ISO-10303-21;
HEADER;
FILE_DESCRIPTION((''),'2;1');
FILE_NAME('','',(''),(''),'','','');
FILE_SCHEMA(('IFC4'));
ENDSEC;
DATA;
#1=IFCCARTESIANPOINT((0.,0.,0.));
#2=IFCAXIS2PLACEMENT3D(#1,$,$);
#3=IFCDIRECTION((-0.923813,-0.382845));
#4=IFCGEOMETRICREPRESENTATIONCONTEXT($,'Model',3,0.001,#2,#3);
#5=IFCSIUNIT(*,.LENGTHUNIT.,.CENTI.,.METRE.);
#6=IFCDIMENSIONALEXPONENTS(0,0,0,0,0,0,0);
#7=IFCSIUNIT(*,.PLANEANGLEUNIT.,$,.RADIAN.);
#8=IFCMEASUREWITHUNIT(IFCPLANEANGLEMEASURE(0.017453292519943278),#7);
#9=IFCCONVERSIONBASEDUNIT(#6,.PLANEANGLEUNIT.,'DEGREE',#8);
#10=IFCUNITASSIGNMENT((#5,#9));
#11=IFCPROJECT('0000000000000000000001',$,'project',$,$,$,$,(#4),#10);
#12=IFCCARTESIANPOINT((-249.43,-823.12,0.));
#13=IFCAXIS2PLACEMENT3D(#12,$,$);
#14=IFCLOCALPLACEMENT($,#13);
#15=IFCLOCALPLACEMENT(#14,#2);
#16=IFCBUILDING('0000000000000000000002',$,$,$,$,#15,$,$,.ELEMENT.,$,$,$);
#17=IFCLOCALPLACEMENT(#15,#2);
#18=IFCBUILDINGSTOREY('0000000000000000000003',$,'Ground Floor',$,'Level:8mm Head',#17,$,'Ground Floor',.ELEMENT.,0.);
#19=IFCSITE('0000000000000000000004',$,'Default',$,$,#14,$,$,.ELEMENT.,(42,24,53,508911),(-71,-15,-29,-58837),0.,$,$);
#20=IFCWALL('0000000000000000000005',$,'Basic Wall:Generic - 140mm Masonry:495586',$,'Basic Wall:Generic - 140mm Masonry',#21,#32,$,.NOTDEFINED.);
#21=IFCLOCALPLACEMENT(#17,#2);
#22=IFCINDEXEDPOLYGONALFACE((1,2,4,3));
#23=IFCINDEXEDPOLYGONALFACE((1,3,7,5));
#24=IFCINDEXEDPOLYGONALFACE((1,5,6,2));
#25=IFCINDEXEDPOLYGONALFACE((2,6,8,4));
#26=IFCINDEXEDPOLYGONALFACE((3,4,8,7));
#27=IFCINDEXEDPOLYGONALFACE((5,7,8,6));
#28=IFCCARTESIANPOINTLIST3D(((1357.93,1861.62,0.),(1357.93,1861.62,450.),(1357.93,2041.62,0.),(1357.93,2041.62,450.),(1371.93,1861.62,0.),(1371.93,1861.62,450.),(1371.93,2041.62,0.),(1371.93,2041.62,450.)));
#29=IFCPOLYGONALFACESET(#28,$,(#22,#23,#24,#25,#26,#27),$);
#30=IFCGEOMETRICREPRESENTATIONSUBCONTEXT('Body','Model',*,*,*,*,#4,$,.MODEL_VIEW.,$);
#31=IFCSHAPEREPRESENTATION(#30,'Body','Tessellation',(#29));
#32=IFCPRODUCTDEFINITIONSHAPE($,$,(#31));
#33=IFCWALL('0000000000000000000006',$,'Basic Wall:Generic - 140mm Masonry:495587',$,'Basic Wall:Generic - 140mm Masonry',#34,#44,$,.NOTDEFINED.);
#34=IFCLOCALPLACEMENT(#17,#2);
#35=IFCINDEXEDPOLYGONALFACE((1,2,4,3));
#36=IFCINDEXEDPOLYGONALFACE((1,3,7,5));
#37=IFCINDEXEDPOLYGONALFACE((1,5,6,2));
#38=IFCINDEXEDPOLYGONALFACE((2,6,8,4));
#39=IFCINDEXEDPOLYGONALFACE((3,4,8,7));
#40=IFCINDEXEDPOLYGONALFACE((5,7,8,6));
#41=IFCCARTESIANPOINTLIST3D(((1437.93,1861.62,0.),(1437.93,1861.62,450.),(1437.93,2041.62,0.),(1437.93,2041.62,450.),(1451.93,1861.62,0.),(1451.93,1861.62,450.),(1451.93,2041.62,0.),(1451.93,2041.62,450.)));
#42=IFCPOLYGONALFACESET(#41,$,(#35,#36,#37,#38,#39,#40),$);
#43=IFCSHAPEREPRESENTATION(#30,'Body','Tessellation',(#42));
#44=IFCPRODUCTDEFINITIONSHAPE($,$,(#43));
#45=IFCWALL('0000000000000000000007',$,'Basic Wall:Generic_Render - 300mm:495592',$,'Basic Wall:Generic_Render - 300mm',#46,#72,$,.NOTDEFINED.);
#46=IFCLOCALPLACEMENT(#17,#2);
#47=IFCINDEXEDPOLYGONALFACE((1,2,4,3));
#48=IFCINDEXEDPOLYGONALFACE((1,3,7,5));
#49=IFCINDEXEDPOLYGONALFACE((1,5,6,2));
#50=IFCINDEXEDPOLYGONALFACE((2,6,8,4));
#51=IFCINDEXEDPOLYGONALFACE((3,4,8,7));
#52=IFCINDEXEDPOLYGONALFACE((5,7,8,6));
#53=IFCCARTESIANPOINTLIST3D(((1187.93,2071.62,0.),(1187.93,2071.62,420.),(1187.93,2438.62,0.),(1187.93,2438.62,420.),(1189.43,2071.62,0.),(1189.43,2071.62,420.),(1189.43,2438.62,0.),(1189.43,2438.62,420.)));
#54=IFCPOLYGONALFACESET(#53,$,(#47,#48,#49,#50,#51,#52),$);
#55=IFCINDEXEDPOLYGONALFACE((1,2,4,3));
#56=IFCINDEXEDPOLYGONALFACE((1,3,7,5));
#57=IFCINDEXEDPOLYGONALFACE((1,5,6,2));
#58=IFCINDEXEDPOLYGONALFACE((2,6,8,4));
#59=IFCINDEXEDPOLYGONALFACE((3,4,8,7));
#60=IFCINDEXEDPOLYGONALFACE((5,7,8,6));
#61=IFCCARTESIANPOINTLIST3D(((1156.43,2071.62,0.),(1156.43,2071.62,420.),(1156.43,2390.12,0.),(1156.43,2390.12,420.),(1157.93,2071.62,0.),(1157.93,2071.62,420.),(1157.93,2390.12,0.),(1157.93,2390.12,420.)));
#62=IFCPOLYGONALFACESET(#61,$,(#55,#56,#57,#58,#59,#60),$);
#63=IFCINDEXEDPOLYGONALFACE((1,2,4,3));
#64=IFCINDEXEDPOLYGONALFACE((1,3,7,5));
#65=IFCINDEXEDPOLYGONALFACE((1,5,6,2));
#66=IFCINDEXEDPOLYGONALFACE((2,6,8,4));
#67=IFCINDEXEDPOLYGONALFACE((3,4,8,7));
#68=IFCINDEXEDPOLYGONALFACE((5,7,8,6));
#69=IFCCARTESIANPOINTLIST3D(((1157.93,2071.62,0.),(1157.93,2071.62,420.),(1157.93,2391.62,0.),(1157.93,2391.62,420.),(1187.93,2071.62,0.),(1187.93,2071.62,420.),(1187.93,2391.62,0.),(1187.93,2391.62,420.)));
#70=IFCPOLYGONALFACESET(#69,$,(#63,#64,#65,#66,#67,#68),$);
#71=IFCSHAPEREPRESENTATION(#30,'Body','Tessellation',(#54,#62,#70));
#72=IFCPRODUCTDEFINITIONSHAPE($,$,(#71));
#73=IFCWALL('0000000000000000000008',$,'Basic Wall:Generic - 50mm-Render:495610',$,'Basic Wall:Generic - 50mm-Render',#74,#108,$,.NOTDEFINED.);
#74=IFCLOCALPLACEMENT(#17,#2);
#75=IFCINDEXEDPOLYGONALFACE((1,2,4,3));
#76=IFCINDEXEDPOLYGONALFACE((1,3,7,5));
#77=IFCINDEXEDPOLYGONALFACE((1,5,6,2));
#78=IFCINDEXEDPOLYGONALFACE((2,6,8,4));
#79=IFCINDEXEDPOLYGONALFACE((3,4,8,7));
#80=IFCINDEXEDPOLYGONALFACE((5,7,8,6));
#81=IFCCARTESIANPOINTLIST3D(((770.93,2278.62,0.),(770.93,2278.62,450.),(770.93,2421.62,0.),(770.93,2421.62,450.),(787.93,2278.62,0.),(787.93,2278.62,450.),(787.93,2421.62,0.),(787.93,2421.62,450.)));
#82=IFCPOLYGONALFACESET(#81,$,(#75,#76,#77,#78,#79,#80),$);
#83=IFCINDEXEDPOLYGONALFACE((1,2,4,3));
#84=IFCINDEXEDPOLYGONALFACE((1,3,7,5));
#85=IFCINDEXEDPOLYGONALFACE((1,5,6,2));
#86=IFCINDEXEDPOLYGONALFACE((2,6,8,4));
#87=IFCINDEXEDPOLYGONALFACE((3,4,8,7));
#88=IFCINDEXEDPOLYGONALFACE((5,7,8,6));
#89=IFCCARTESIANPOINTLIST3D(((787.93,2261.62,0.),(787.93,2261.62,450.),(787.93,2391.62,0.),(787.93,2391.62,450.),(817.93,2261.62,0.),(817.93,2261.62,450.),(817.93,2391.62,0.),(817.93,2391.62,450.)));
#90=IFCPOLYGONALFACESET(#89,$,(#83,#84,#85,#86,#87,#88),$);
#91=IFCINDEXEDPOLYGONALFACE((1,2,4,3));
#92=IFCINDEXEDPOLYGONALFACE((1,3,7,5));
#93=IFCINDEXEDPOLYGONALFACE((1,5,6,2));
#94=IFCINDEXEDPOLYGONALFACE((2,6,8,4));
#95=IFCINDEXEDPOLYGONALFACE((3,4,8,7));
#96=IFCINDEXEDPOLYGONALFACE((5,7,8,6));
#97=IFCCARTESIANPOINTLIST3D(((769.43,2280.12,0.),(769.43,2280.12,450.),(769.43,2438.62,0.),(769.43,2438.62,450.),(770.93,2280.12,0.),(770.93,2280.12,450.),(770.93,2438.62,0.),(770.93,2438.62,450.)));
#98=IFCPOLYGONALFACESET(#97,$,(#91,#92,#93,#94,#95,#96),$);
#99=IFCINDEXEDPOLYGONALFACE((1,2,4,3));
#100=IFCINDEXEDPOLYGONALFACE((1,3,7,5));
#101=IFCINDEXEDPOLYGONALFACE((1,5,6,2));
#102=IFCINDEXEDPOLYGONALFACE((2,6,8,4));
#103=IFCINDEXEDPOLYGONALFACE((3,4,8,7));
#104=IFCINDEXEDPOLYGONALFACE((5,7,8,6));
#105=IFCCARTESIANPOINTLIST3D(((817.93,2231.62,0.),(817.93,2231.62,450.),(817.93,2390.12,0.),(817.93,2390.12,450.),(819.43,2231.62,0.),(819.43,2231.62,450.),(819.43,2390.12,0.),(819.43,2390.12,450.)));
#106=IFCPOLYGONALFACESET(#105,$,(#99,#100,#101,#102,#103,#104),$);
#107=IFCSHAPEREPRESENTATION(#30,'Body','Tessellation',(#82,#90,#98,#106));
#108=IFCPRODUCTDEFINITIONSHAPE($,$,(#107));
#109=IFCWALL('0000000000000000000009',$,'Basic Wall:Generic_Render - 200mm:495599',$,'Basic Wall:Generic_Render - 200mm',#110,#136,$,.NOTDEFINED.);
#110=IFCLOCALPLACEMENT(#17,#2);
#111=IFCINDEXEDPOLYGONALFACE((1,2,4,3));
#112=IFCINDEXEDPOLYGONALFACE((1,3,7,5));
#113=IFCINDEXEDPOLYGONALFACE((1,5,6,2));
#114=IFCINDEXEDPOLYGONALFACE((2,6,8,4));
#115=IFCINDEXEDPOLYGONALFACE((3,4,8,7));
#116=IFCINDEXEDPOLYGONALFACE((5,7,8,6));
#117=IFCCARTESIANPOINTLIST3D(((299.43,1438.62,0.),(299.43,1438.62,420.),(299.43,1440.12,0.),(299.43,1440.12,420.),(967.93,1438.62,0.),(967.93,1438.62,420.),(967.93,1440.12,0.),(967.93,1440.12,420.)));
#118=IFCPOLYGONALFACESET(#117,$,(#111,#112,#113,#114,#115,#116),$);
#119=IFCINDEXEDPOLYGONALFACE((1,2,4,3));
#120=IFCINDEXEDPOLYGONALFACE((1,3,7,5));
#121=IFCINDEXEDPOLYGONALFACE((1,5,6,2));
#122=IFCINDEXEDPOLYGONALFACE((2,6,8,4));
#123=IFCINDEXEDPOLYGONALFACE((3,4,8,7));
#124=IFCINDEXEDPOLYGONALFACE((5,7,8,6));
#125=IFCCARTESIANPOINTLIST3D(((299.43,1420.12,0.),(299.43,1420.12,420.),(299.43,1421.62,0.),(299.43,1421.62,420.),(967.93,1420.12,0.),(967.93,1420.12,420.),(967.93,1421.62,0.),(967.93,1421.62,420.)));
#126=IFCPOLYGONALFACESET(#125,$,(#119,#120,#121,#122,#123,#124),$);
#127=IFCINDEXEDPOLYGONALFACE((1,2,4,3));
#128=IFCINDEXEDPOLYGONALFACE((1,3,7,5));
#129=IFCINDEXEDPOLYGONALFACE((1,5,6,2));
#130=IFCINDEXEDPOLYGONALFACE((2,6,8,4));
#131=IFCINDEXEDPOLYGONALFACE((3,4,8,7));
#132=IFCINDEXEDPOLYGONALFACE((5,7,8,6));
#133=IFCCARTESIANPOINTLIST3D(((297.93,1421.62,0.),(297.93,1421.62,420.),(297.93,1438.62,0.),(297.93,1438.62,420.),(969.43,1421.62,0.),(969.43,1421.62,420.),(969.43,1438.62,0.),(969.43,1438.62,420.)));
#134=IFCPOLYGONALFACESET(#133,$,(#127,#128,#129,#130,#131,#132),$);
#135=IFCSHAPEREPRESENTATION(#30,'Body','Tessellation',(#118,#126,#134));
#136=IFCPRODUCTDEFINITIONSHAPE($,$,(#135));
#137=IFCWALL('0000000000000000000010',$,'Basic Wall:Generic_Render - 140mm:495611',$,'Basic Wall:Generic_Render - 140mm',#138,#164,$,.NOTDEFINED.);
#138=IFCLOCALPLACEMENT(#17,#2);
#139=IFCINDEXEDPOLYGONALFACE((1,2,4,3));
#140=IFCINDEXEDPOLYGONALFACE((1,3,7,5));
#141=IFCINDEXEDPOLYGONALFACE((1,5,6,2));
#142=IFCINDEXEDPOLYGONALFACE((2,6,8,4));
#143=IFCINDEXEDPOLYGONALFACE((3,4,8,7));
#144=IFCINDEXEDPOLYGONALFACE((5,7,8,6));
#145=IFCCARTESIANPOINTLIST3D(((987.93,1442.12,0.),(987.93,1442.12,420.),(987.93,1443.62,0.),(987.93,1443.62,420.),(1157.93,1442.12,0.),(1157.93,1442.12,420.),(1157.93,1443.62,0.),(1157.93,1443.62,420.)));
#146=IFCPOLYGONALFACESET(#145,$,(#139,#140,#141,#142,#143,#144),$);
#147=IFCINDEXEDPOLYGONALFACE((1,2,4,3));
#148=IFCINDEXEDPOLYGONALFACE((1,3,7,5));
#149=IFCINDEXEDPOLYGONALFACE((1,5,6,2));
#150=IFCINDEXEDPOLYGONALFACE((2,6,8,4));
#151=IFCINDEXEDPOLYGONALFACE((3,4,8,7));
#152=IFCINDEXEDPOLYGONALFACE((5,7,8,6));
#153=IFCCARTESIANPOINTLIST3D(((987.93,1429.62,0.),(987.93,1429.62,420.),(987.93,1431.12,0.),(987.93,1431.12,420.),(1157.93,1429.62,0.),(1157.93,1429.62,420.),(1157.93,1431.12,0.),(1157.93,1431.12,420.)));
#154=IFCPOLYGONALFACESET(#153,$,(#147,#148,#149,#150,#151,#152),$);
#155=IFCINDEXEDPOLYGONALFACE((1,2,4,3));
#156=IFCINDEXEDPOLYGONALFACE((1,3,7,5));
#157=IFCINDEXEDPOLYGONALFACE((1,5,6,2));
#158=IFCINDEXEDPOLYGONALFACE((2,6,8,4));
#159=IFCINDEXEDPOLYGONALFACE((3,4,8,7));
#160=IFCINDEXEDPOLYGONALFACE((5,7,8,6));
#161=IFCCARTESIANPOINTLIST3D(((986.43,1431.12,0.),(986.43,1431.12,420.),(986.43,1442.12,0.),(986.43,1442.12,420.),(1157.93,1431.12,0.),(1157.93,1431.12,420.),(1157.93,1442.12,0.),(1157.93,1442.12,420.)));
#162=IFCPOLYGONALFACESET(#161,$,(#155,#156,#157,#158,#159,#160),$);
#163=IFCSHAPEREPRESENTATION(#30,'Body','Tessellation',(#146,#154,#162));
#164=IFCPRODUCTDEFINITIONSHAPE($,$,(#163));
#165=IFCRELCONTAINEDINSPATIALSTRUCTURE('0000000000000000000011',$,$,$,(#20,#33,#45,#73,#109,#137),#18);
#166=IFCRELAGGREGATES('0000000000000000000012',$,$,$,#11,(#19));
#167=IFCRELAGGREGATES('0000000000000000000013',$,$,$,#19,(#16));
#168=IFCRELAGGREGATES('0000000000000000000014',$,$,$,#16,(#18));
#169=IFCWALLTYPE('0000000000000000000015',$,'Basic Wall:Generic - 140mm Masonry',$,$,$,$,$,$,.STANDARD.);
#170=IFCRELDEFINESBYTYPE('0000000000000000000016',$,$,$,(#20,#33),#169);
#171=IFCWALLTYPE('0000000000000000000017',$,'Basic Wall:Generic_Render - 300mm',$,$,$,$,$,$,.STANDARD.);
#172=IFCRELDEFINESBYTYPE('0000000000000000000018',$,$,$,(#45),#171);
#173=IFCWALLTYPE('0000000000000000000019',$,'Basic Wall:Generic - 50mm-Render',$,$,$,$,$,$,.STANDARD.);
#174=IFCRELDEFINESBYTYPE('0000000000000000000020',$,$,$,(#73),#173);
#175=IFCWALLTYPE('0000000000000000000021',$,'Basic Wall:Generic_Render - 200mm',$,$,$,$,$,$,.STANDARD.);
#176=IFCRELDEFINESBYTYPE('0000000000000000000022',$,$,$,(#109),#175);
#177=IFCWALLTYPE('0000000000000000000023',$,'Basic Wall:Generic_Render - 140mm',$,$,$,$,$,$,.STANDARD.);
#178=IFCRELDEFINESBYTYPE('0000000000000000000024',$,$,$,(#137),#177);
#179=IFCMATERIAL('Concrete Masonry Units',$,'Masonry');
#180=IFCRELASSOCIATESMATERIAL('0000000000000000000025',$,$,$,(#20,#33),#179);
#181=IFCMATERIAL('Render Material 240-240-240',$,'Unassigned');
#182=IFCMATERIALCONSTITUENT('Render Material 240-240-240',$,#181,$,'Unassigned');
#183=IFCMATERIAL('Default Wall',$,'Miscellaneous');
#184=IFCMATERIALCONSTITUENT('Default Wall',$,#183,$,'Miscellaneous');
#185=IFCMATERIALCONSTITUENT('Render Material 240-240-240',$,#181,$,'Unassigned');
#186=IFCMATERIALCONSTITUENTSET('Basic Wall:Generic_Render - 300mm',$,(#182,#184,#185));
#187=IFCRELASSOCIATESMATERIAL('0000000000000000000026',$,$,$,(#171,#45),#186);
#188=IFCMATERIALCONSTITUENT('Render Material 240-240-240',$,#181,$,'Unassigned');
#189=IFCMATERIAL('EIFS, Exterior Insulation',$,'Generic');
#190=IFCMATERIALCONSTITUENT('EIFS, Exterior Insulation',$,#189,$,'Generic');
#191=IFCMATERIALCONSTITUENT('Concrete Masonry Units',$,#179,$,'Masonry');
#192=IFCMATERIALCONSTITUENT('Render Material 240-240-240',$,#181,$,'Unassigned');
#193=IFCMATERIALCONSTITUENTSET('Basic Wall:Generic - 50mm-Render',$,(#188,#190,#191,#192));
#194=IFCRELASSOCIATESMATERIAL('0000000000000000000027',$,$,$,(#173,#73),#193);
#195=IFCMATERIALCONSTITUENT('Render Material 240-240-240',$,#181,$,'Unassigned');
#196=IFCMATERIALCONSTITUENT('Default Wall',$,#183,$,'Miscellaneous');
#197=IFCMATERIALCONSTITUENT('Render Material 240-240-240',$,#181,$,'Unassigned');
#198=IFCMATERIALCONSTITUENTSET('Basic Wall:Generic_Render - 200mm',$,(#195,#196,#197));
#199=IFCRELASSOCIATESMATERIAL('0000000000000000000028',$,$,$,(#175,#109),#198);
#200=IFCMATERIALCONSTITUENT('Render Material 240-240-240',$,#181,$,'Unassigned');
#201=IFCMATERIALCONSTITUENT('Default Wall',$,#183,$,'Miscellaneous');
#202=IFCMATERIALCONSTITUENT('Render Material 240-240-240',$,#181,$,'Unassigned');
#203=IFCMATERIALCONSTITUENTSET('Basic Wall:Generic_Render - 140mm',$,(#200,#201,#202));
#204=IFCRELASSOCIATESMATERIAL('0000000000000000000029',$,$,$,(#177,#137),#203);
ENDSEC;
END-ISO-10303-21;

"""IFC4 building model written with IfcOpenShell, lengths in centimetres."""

from ifc_helpers import new_model, entity, si_unit, converted_unit, direction, frame, origin, place, context, subcontext, project, spatial, indexed_curve, outline, extrude, material, constituent, constituent_set, type_object, element, save


model = new_model("IFC4")

# Units and contexts
model_context = context("Model", 3, precision=0.001, world=origin(), true_north=direction((-0.923813, -0.382845)))
body_context = subcontext(model_context, "Body", "Model", "MODEL_VIEW")
ifc_project = project(units=[si_unit("LENGTHUNIT", "METRE", prefix="CENTI"), converted_unit("PLANEANGLEUNIT", "DEGREE", entity("IfcPlaneAngleMeasure", 0.017453292519943278), si_unit("PLANEANGLEUNIT", "RADIAN"), dimensions=[0, 0, 0, 0, 0, 0, 0])], contexts=[model_context])

# Site, building, storey
site_placement = place(None, frame((-249.43, -823.12, 0.0)))
site = spatial("IfcSite", under=ifc_project, at=site_placement, Name="Default", CompositionType="ELEMENT", RefLatitude=(42, 24, 53, 508911), RefLongitude=(-71, -15, -29, -58837), RefElevation=0.0)
building_placement = place(site_placement, origin())
building = spatial("IfcBuilding", under=site, at=building_placement, CompositionType="ELEMENT")
storey_placement = place(building_placement, origin())
storey = spatial("IfcBuildingStorey", under=building, at=storey_placement, Name="Ground Floor", ObjectType="Level:8mm Head", LongName="Ground Floor", CompositionType="ELEMENT", Elevation=0.0)

# Walls
ifc_material_1 = material(Name="Concrete Masonry Units", Category="Masonry")
wall_type_1 = type_object("IfcWallType", Name="Basic Wall:Generic - 140mm Masonry", PredefinedType="STANDARD")
wall_1_placement = place(storey_placement, frame((1364.93, 2041.62, 0.0), z_axis=(0.0, 0.0, 1.0), x_axis=(0.0, -1.0, 0.0)))
element("IfcWall", 1, at=wall_1_placement, inside=storey, type_object=wall_type_1, material=ifc_material_1, Name="Basic Wall:Generic - 140mm Masonry:495586", ObjectType="Basic Wall:Generic - 140mm Masonry", PredefinedType="NOTDEFINED", context=body_context, shape_type="SweptSolid", body=[
    extrude(outline(indexed_curve([(180.0, 7.0), (0.0, 7.0), (0.0, -7.0), (180.0, -7.0), (180.0, 7.0)], self_intersect=False)), origin(), (0.0, 0.0, 1.0), 450.0),
])
wall_2_placement = place(storey_placement, frame((1444.93, 2041.62, 0.0), z_axis=(0.0, 0.0, 1.0), x_axis=(0.0, -1.0, 0.0)))
element("IfcWall", 2, at=wall_2_placement, inside=storey, type_object=wall_type_1, material=ifc_material_1, Name="Basic Wall:Generic - 140mm Masonry:495587", ObjectType="Basic Wall:Generic - 140mm Masonry", PredefinedType="NOTDEFINED", context=body_context, shape_type="SweptSolid", body=[
    extrude(outline(indexed_curve([(180.0, 7.0), (0.0, 7.0), (0.0, -7.0), (180.0, -7.0), (180.0, 7.0)], self_intersect=False)), origin(), (0.0, 0.0, 1.0), 450.0),
])
ifc_material_2 = material(Name="Render Material 240-240-240", Category="Unassigned")
ifc_constituent_1 = constituent(ifc_material_2, Name="Render Material 240-240-240", Category="Unassigned")
ifc_material_3 = material(Name="Default Wall", Category="Miscellaneous")
ifc_constituent_2 = constituent(ifc_material_3, Name="Default Wall", Category="Miscellaneous")
ifc_constituent_3 = constituent(ifc_material_2, Name="Render Material 240-240-240", Category="Unassigned")
ifc_constituent_set_1 = constituent_set(constituents=[ifc_constituent_1, ifc_constituent_2, ifc_constituent_3], Name="Basic Wall:Generic_Render - 300mm")
wall_type_2 = type_object("IfcWallType", Name="Basic Wall:Generic_Render - 300mm", PredefinedType="STANDARD", material=ifc_constituent_set_1)
wall_3_placement = place(storey_placement, frame((1172.93, 2071.62, 0.0), z_axis=(0.0, 0.0, 1.0), x_axis=(0.0, 1.0, 0.0)))
element("IfcWall", 3, at=wall_3_placement, inside=storey, type_object=wall_type_2, material=ifc_constituent_set_1, Name="Basic Wall:Generic_Render - 300mm:495592", ObjectType="Basic Wall:Generic_Render - 300mm", PredefinedType="NOTDEFINED", context=body_context, shape_type="SweptSolid", body=[
    extrude(outline(indexed_curve([(-0.75, -183.5), (0.75, -183.5), (0.75, 183.5), (-0.75, 183.5), (-0.75, -183.5)], self_intersect=False)), frame((183.5, -15.75, 0.0), z_axis=(0.0, 0.0, 1.0), x_axis=(0.0, 1.0, 0.0)), (0.0, 0.0, 1.0), 420.0),
    extrude(outline(indexed_curve([(-0.75, -159.25), (0.75, -159.25), (0.75, 159.25), (-0.75, 159.25), (-0.75, -159.25)], self_intersect=False)), frame((159.25, 15.75, 0.0), z_axis=(0.0, 0.0, 1.0), x_axis=(0.0, -1.0, 0.0)), (0.0, 0.0, 1.0), 420.0),
    extrude(outline(indexed_curve([(-160.0, -15.0), (160.0, -15.0), (160.0, 15.0), (-160.0, 15.0), (-160.0, -15.0)], self_intersect=False)), frame((160.0, 0.0, 0.0)), (0.0, 0.0, 1.0), 420.0),
])
ifc_constituent_4 = constituent(ifc_material_2, Name="Render Material 240-240-240", Category="Unassigned")
ifc_material_4 = material(Name="EIFS, Exterior Insulation", Category="Generic")
ifc_constituent_5 = constituent(ifc_material_4, Name="EIFS, Exterior Insulation", Category="Generic")
ifc_constituent_6 = constituent(ifc_material_1, Name="Concrete Masonry Units", Category="Masonry")
ifc_constituent_7 = constituent(ifc_material_2, Name="Render Material 240-240-240", Category="Unassigned")
ifc_constituent_set_2 = constituent_set(constituents=[ifc_constituent_4, ifc_constituent_5, ifc_constituent_6, ifc_constituent_7], Name="Basic Wall:Generic - 50mm-Render")
wall_type_3 = type_object("IfcWallType", Name="Basic Wall:Generic - 50mm-Render", PredefinedType="STANDARD", material=ifc_constituent_set_2)
wall_4_placement = place(storey_placement, frame((794.43, 2280.12, 0.0), z_axis=(0.0, 0.0, 1.0), x_axis=(0.0, 1.0, 0.0)))
element("IfcWall", 4, at=wall_4_placement, inside=storey, type_object=wall_type_3, material=ifc_constituent_set_2, Name="Basic Wall:Generic - 50mm-Render:495610", ObjectType="Basic Wall:Generic - 50mm-Render", PredefinedType="NOTDEFINED", context=body_context, shape_type="SweptSolid", body=[
    extrude(outline(indexed_curve([(-71.5, -8.5), (71.5, -8.5), (71.5, 8.5), (-71.5, 8.5), (-71.5, -8.5)], self_intersect=False)), frame((70.0, 15.0, 0.0)), (0.0, 0.0, 1.0), 450.0),
    extrude(outline(indexed_curve([(-65.0, -15.0), (65.0, -15.0), (65.0, 15.0), (-65.0, 15.0), (-65.0, -15.0)], self_intersect=False)), frame((46.5, -8.5, 0.0)), (0.0, 0.0, 1.0), 450.0),
    extrude(outline(indexed_curve([(-0.75, -79.25), (0.75, -79.25), (0.75, 79.25), (-0.75, 79.25), (-0.75, -79.25)], self_intersect=False)), frame((79.25, 24.25, 0.0), z_axis=(0.0, 0.0, 1.0), x_axis=(0.0, -1.0, 0.0)), (0.0, 0.0, 1.0), 450.0),
    extrude(outline(indexed_curve([(-0.75, -79.25), (0.75, -79.25), (0.75, 79.25), (-0.75, 79.25), (-0.75, -79.25)], self_intersect=False)), frame((30.75, -24.25, 0.0), z_axis=(0.0, 0.0, 1.0), x_axis=(0.0, 1.0, 0.0)), (0.0, 0.0, 1.0), 450.0),
])
ifc_constituent_8 = constituent(ifc_material_2, Name="Render Material 240-240-240", Category="Unassigned")
ifc_constituent_9 = constituent(ifc_material_3, Name="Default Wall", Category="Miscellaneous")
ifc_constituent_10 = constituent(ifc_material_2, Name="Render Material 240-240-240", Category="Unassigned")
ifc_constituent_set_3 = constituent_set(constituents=[ifc_constituent_8, ifc_constituent_9, ifc_constituent_10], Name="Basic Wall:Generic_Render - 200mm")
wall_type_4 = type_object("IfcWallType", Name="Basic Wall:Generic_Render - 200mm", PredefinedType="STANDARD", material=ifc_constituent_set_3)
wall_5_placement = place(storey_placement, frame((967.93, 1430.12, 0.0), z_axis=(0.0, 0.0, 1.0), x_axis=(-1.0, 0.0, 0.0)))
element("IfcWall", 5, at=wall_5_placement, inside=storey, type_object=wall_type_4, material=ifc_constituent_set_3, Name="Basic Wall:Generic_Render - 200mm:495599", ObjectType="Basic Wall:Generic_Render - 200mm", PredefinedType="NOTDEFINED", context=body_context, shape_type="SweptSolid", body=[
    extrude(outline(indexed_curve([(-0.75, -334.25), (0.75, -334.25), (0.75, 334.25), (-0.75, 334.25), (-0.75, -334.25)], self_intersect=False)), frame((334.25, -9.25, 0.0), z_axis=(0.0, 0.0, 1.0), x_axis=(0.0, 1.0, 0.0)), (0.0, 0.0, 1.0), 420.0),
    extrude(outline(indexed_curve([(-0.75, -334.25), (0.75, -334.25), (0.75, 334.25), (-0.75, 334.25), (-0.75, -334.25)], self_intersect=False)), frame((334.25, 9.25, 0.0), z_axis=(0.0, 0.0, 1.0), x_axis=(0.0, -1.0, 0.0)), (0.0, 0.0, 1.0), 420.0),
    extrude(outline(indexed_curve([(-335.75, -8.5), (335.75, -8.5), (335.75, 8.5), (-335.75, 8.5), (-335.75, -8.5)], self_intersect=False)), frame((334.25, 0.0, 0.0)), (0.0, 0.0, 1.0), 420.0),
])

# Wall
ifc_constituent_11 = constituent(ifc_material_2, Name="Render Material 240-240-240", Category="Unassigned")
ifc_constituent_12 = constituent(ifc_material_3, Name="Default Wall", Category="Miscellaneous")
ifc_constituent_13 = constituent(ifc_material_2, Name="Render Material 240-240-240", Category="Unassigned")
ifc_constituent_set_4 = constituent_set(constituents=[ifc_constituent_11, ifc_constituent_12, ifc_constituent_13], Name="Basic Wall:Generic_Render - 140mm")
wall_type_5 = type_object("IfcWallType", Name="Basic Wall:Generic_Render - 140mm", PredefinedType="STANDARD", material=ifc_constituent_set_4)
wall_6_placement = place(storey_placement, frame((1157.93, 1436.62, 0.0), z_axis=(0.0, 0.0, 1.0), x_axis=(-1.0, 0.0, 0.0)))
element("IfcWall", 6, at=wall_6_placement, inside=storey, type_object=wall_type_5, material=ifc_constituent_set_4, Name="Basic Wall:Generic_Render - 140mm:495611", ObjectType="Basic Wall:Generic_Render - 140mm", PredefinedType="NOTDEFINED", context=body_context, shape_type="SweptSolid", body=[
    extrude(outline(indexed_curve([(-0.75, -85.0), (0.75, -85.0), (0.75, 85.0), (-0.75, 85.0), (-0.75, -85.0)], self_intersect=False)), frame((85.0, -6.25, 0.0), z_axis=(0.0, 0.0, 1.0), x_axis=(0.0, 1.0, 0.0)), (0.0, 0.0, 1.0), 420.0),
    extrude(outline(indexed_curve([(-0.75, -85.0), (0.75, -85.0), (0.75, 85.0), (-0.75, 85.0), (-0.75, -85.0)], self_intersect=False)), frame((85.0, 6.25, 0.0), z_axis=(0.0, 0.0, 1.0), x_axis=(0.0, -1.0, 0.0)), (0.0, 0.0, 1.0), 420.0),
    extrude(outline(indexed_curve([(-85.75, -5.5), (85.75, -5.5), (85.75, 5.5), (-85.75, 5.5), (-85.75, -5.5)], self_intersect=False)), frame((85.75, 0.0, 0.0)), (0.0, 0.0, 1.0), 420.0),
])

save(model, "model.ifc")
